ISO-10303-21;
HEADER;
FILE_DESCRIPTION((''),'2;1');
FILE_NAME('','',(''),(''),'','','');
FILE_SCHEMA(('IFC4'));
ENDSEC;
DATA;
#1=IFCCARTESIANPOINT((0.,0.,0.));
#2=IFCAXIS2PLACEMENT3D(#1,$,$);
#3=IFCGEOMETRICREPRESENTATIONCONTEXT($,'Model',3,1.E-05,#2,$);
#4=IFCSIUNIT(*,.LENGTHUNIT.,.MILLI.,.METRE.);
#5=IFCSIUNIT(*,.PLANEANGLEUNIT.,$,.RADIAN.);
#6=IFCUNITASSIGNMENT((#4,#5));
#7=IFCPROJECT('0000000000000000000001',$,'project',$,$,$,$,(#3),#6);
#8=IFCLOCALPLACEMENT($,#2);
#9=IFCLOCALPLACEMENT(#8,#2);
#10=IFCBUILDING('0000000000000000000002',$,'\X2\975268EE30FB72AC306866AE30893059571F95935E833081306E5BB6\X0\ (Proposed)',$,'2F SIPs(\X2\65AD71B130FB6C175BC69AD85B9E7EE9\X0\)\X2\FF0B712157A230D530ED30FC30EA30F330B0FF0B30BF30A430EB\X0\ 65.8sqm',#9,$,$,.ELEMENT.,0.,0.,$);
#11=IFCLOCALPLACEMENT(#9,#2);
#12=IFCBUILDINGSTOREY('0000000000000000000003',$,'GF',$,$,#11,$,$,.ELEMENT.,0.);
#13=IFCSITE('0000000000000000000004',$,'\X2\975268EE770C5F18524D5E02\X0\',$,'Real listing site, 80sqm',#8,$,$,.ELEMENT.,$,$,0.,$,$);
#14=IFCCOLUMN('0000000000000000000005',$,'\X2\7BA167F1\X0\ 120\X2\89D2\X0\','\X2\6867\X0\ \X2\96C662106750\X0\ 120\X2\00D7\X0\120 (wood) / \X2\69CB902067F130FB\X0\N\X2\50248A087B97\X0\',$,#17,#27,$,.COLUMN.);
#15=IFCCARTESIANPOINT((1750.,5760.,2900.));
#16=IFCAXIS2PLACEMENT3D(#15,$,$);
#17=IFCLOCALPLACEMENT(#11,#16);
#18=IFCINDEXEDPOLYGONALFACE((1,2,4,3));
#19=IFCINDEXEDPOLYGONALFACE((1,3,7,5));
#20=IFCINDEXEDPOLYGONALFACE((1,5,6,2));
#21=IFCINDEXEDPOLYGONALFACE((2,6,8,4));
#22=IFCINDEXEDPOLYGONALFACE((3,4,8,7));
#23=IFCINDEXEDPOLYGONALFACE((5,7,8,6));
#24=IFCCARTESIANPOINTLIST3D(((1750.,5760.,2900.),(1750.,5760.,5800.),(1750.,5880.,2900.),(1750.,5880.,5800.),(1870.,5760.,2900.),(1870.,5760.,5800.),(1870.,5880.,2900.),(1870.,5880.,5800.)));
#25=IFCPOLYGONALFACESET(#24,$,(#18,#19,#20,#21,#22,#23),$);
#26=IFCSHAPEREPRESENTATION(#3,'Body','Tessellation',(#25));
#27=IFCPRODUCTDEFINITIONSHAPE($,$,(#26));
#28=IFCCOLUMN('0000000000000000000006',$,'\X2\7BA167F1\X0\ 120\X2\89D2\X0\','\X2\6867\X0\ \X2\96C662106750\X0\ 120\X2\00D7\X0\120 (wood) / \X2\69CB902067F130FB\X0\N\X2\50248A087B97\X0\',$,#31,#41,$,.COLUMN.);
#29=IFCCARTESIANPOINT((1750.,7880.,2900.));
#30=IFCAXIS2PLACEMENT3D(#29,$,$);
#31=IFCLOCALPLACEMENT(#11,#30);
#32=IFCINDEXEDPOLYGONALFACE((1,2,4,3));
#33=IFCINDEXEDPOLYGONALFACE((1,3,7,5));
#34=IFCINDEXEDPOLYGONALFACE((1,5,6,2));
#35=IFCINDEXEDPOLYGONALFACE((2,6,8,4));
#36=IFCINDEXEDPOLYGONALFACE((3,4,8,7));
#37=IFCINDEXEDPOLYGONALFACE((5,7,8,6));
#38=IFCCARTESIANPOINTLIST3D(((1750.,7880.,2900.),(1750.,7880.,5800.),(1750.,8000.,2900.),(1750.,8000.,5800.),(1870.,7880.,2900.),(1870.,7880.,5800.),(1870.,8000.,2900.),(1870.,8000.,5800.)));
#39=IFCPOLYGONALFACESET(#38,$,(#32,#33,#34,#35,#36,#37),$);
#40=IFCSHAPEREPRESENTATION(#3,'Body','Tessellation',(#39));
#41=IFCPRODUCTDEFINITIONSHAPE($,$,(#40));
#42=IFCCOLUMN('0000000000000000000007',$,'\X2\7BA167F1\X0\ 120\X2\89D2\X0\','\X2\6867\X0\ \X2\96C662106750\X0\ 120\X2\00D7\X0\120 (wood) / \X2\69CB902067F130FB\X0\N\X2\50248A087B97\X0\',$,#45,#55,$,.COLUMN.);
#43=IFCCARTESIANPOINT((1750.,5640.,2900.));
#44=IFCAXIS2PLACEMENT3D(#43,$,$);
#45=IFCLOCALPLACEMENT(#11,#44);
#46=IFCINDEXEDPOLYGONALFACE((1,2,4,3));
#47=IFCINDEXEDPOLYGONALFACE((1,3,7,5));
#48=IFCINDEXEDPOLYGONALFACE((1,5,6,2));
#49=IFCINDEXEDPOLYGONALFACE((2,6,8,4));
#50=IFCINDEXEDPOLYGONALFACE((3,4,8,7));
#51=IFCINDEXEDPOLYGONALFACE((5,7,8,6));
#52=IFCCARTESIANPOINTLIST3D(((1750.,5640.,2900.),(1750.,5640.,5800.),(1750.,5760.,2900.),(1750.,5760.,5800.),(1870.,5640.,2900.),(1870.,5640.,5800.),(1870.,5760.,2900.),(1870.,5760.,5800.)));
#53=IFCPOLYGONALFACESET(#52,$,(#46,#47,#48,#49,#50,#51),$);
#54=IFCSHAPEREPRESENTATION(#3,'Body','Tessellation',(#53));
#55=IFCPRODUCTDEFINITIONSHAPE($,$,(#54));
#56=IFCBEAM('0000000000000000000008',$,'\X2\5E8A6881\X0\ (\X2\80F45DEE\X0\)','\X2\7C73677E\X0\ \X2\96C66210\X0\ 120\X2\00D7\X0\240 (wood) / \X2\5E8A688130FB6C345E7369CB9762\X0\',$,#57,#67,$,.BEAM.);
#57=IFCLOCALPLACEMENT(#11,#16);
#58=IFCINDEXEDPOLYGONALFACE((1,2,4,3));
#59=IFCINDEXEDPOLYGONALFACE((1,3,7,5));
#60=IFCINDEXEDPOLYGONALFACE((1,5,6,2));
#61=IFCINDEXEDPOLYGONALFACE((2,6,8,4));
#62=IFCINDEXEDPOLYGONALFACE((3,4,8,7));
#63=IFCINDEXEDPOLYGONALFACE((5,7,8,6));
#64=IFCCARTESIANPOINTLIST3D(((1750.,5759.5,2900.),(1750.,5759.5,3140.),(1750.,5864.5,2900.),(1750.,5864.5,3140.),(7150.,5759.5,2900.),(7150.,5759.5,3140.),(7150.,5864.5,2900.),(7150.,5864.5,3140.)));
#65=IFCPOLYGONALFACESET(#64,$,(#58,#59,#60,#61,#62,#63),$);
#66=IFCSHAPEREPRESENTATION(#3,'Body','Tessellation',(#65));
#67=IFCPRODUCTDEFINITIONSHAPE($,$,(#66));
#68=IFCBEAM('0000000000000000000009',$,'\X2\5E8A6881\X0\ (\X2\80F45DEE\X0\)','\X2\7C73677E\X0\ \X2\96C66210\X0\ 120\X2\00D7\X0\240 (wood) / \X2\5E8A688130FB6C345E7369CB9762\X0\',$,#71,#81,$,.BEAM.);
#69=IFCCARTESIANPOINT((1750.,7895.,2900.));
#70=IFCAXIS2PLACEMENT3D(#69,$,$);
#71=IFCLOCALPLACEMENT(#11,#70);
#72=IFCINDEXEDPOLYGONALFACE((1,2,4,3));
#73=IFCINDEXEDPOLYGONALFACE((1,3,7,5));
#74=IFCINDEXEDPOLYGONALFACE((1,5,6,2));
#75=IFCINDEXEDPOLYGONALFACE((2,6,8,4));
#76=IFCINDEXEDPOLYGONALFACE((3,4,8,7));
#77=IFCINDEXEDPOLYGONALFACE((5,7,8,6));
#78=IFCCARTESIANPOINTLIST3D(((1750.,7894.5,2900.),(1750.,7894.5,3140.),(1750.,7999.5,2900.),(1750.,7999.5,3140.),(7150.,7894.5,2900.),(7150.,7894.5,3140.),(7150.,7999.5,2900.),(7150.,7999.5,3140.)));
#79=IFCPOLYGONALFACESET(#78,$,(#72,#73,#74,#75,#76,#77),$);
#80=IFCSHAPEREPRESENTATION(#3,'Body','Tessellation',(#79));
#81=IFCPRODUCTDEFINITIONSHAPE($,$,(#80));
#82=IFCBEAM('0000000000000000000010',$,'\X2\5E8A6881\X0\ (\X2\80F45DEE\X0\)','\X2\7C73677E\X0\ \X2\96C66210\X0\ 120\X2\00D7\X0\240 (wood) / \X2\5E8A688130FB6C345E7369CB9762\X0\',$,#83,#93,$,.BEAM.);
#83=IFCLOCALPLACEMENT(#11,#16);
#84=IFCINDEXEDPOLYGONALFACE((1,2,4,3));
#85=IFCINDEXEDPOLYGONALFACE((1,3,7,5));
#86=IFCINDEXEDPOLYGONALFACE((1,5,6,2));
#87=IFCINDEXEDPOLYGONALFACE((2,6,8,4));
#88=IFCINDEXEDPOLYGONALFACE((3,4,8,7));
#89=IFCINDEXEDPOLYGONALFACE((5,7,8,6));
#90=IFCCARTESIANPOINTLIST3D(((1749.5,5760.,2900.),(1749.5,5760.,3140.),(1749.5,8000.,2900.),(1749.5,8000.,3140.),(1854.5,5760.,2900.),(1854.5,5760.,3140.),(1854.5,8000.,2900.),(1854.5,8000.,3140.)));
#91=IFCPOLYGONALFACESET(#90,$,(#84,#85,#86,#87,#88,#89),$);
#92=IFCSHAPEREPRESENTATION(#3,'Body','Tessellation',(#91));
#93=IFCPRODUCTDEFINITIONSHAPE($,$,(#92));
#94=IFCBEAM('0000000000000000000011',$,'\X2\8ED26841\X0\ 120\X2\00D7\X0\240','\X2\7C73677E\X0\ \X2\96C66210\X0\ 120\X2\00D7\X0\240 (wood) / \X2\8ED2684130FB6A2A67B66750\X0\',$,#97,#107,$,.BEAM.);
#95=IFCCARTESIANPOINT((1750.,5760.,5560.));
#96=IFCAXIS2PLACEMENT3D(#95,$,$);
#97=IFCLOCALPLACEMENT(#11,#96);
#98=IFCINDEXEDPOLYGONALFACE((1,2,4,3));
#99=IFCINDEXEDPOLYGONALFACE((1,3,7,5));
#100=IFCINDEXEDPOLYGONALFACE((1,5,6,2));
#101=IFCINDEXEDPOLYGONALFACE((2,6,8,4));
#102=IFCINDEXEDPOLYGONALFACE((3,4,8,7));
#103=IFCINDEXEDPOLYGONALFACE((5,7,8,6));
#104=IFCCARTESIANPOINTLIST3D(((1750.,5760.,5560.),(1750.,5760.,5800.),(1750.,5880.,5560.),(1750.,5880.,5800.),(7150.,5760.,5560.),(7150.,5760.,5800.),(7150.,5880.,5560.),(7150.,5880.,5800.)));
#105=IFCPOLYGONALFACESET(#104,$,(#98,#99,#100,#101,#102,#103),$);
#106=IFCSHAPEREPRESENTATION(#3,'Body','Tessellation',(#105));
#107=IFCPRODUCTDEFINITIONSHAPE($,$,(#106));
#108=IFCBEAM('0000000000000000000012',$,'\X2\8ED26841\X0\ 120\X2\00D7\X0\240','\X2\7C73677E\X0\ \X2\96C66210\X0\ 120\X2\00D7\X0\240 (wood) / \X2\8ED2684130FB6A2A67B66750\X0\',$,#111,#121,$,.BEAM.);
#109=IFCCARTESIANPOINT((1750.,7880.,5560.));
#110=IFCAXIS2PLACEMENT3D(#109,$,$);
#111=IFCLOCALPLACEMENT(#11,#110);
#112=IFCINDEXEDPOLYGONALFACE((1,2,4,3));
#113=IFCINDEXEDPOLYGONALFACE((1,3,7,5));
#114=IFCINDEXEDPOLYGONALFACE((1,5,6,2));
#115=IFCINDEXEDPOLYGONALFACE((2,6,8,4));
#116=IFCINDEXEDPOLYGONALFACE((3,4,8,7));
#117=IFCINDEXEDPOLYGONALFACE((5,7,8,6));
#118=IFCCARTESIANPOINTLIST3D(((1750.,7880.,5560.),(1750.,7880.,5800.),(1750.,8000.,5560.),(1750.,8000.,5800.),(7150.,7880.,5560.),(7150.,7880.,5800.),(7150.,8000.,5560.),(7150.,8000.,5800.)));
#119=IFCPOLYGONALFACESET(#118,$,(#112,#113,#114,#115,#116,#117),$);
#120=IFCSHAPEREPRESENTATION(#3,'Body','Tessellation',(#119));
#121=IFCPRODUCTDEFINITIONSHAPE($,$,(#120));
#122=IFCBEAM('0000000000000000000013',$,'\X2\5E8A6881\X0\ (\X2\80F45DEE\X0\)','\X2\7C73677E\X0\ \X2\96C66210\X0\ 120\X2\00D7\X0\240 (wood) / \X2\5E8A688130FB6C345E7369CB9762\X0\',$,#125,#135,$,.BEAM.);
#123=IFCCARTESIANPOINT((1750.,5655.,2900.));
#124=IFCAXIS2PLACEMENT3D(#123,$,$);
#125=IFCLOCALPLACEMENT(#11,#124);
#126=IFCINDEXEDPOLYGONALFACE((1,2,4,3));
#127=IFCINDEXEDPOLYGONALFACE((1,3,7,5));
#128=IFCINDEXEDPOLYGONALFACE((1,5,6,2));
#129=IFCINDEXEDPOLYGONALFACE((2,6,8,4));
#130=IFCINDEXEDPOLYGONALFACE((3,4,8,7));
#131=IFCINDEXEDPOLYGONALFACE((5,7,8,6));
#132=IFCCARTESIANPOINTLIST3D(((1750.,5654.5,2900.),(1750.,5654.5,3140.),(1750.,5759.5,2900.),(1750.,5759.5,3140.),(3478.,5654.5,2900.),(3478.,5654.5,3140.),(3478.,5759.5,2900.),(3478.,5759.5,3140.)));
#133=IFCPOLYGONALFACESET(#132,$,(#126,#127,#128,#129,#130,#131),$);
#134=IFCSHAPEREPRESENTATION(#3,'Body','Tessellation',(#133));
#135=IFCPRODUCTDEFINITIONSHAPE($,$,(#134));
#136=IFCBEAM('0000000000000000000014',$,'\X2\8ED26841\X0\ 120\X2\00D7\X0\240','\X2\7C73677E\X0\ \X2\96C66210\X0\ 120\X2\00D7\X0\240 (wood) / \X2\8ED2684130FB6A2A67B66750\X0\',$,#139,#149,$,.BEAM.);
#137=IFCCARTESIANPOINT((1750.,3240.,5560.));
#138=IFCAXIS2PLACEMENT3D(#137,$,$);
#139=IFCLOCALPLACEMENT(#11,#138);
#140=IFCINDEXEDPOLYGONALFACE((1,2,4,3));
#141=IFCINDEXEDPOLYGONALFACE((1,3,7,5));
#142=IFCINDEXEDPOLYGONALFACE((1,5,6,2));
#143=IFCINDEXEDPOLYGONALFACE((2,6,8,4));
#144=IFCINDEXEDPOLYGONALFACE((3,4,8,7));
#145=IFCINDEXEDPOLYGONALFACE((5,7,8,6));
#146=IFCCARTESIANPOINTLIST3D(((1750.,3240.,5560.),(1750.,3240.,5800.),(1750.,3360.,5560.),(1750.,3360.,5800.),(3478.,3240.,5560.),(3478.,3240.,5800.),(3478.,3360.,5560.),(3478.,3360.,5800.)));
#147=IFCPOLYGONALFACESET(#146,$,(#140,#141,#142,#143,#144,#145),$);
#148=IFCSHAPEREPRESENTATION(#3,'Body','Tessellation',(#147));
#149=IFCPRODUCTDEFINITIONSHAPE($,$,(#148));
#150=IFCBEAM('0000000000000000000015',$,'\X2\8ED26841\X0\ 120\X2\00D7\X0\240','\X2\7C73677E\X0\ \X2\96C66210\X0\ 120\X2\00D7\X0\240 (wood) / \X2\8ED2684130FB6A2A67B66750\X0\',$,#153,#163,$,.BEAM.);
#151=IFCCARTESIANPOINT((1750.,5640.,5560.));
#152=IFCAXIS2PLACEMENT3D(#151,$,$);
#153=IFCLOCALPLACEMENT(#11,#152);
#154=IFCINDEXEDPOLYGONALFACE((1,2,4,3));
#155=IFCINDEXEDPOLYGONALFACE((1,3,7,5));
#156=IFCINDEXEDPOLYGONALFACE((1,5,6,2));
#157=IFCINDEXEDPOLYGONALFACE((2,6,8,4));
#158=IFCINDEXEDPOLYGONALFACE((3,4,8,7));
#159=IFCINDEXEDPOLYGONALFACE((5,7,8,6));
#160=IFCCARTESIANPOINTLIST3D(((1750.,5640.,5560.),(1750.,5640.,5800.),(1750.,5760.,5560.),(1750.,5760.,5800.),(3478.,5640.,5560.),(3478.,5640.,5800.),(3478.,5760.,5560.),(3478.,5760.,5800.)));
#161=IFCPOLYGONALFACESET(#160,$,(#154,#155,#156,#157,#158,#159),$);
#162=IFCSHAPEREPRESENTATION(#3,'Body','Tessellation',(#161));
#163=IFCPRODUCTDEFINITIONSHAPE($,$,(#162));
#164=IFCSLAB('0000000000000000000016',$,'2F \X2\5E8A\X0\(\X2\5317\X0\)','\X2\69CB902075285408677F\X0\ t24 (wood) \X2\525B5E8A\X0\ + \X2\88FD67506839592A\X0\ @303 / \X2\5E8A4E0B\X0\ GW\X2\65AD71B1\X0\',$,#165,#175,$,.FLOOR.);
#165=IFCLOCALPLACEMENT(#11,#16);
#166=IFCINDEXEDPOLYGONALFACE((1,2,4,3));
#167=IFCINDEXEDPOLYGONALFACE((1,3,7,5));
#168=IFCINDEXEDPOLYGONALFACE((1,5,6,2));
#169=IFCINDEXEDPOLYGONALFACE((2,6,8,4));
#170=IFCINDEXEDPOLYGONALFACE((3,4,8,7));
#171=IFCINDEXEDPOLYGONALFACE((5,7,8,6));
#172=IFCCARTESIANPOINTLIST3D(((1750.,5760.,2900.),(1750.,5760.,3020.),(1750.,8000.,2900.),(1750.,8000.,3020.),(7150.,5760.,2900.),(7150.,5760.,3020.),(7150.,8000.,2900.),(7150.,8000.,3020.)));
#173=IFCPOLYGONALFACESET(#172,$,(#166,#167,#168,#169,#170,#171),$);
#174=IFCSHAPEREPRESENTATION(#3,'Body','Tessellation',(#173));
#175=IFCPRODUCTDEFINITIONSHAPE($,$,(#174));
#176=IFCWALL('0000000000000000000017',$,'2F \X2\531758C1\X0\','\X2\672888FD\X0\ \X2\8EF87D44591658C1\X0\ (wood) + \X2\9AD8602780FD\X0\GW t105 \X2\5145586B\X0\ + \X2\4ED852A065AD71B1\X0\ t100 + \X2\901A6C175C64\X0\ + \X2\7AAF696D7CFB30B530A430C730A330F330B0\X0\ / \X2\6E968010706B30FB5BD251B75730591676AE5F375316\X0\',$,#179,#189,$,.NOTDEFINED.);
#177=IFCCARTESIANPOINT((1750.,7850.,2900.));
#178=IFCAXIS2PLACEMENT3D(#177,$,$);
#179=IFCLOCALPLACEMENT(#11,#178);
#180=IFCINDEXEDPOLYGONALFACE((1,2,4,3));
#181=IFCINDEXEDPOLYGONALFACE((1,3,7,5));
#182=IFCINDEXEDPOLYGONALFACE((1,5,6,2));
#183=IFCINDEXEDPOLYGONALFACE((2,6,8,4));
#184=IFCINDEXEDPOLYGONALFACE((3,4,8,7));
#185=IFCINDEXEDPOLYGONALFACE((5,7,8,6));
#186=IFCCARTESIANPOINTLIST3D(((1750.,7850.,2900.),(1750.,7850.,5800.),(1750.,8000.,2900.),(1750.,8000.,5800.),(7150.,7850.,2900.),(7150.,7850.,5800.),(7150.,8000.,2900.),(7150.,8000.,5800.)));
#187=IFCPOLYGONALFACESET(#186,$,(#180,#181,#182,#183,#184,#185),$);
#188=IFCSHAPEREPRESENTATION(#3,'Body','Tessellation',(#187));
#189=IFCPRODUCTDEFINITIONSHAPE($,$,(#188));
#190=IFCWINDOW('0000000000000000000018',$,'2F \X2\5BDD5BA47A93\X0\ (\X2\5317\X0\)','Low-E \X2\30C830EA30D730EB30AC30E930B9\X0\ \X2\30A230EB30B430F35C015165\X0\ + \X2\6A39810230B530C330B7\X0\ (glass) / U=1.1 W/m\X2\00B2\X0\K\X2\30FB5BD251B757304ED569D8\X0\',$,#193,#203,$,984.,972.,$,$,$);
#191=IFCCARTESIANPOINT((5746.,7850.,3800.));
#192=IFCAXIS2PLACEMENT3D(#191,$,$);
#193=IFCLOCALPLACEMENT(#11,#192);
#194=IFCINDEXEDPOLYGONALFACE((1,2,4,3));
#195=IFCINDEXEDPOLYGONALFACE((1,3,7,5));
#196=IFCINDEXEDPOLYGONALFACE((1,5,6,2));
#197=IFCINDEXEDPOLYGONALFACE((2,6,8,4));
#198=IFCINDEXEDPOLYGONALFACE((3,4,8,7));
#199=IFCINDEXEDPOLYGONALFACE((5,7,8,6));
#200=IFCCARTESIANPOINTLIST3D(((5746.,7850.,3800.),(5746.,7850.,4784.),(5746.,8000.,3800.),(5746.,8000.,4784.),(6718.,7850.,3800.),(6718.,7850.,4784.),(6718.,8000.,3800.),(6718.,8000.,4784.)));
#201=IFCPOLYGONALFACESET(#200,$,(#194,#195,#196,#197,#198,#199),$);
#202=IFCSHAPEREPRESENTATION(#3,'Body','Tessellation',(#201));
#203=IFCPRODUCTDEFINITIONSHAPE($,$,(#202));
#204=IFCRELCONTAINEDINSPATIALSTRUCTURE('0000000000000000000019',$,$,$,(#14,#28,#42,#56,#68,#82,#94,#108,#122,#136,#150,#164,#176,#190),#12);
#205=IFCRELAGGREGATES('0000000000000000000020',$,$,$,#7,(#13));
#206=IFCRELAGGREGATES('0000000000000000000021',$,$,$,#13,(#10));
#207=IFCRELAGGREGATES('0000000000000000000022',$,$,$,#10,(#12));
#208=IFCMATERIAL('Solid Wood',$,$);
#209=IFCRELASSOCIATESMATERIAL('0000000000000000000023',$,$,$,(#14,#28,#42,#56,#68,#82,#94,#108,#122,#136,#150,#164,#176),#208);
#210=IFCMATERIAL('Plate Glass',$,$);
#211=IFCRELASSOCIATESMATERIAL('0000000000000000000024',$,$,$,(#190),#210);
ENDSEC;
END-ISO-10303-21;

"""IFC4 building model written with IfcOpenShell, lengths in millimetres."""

from ifc_helpers import new_model, si_unit, frame, frame_2d, origin, place, context, project, spatial, rectangle, extrude, material, element, fill, save


model = new_model("IFC4")

# Units and contexts
model_context = context("Model", 3, precision=1e-05, world=origin())
ifc_project = project(units=[si_unit("LENGTHUNIT", "METRE", prefix="MILLI"), si_unit("PLANEANGLEUNIT", "RADIAN")], contexts=[model_context])

# Site, building, storey
site_placement = place(None, origin())
site = spatial("IfcSite", under=ifc_project, at=site_placement, Name="青森県弘前市", ObjectType="Real listing site, 80sqm", CompositionType="ELEMENT", RefElevation=0.0)
building_placement = place(site_placement, origin())
building = spatial("IfcBuilding", under=site, at=building_placement, Name="青森・犬と暮らす土間広めの家 (Proposed)", ObjectType="2F SIPs(断熱・気密高实绩)＋無垢フローリング＋タイル 65.8sqm", CompositionType="ELEMENT", ElevationOfRefHeight=0.0, ElevationOfTerrain=0.0)
storey_placement = place(building_placement, origin())
storey = spatial("IfcBuildingStorey", under=building, at=storey_placement, Name="GF", CompositionType="ELEMENT", Elevation=0.0)

# Columns
ifc_material_1 = material(Name="Solid Wood")
column_1_placement = place(storey_placement, frame((1750.0, 5760.0, 2900.0)))
element("IfcColumn", 1, at=column_1_placement, inside=storey, material=ifc_material_1, Name="管柱 120角", Description="桧 集成材 120×120 (wood) / 構造柱・N値計算", PredefinedType="COLUMN", context=model_context, shape_type="SweptSolid", body=[
    extrude(rectangle(XDim=120.0, YDim=120.0, at=frame_2d((60.0, 60.0))), frame((1750.0, 5760.0, 2900.0)), (0.0, 0.0, 1.0), 2900.0),
])
column_2_placement = place(storey_placement, frame((1750.0, 7880.0, 2900.0)))
element("IfcColumn", 2, at=column_2_placement, inside=storey, material=ifc_material_1, Name="管柱 120角", Description="桧 集成材 120×120 (wood) / 構造柱・N値計算", PredefinedType="COLUMN", context=model_context, shape_type="SweptSolid", body=[
    extrude(rectangle(XDim=120.0, YDim=120.0, at=frame_2d((60.0, 60.0))), frame((1750.0, 7880.0, 2900.0)), (0.0, 0.0, 1.0), 2900.0),
])
column_3_placement = place(storey_placement, frame((1750.0, 5640.0, 2900.0)))
element("IfcColumn", 3, at=column_3_placement, inside=storey, material=ifc_material_1, Name="管柱 120角", Description="桧 集成材 120×120 (wood) / 構造柱・N値計算", PredefinedType="COLUMN", context=model_context, shape_type="SweptSolid", body=[
    extrude(rectangle(XDim=120.0, YDim=120.0, at=frame_2d((60.0, 60.0))), frame((1750.0, 5640.0, 2900.0)), (0.0, 0.0, 1.0), 2900.0),
])

# Beams
beam_1_placement = place(storey_placement, frame((1750.0, 5760.0, 2900.0)))
element("IfcBeam", 4, at=beam_1_placement, inside=storey, material=ifc_material_1, Name="床梁 (胴差)", Description="米松 集成 120×240 (wood) / 床梁・水平構面", PredefinedType="BEAM", context=model_context, shape_type="SweptSolid", body=[
    extrude(rectangle(XDim=5400.0, YDim=105.0, at=frame_2d((2700.0, 52.0))), frame((1750.0, 5760.0, 2900.0)), (0.0, 0.0, 1.0), 240.0),
])
beam_2_placement = place(storey_placement, frame((1750.0, 7895.0, 2900.0)))
element("IfcBeam", 5, at=beam_2_placement, inside=storey, material=ifc_material_1, Name="床梁 (胴差)", Description="米松 集成 120×240 (wood) / 床梁・水平構面", PredefinedType="BEAM", context=model_context, shape_type="SweptSolid", body=[
    extrude(rectangle(XDim=5400.0, YDim=105.0, at=frame_2d((2700.0, 52.0))), frame((1750.0, 7895.0, 2900.0)), (0.0, 0.0, 1.0), 240.0),
])
beam_3_placement = place(storey_placement, frame((1750.0, 5760.0, 2900.0)))
element("IfcBeam", 6, at=beam_3_placement, inside=storey, material=ifc_material_1, Name="床梁 (胴差)", Description="米松 集成 120×240 (wood) / 床梁・水平構面", PredefinedType="BEAM", context=model_context, shape_type="SweptSolid", body=[
    extrude(rectangle(XDim=105.0, YDim=2240.0, at=frame_2d((52.0, 1120.0))), frame((1750.0, 5760.0, 2900.0)), (0.0, 0.0, 1.0), 240.0),
])
beam_4_placement = place(storey_placement, frame((1750.0, 5760.0, 5560.0)))
element("IfcBeam", 7, at=beam_4_placement, inside=storey, material=ifc_material_1, Name="軒桁 120×240", Description="米松 集成 120×240 (wood) / 軒桁・横架材", PredefinedType="BEAM", context=model_context, shape_type="SweptSolid", body=[
    extrude(rectangle(XDim=5400.0, YDim=120.0, at=frame_2d((2700.0, 60.0))), frame((1750.0, 5760.0, 5560.0)), (0.0, 0.0, 1.0), 240.0),
])
beam_5_placement = place(storey_placement, frame((1750.0, 7880.0, 5560.0)))
element("IfcBeam", 8, at=beam_5_placement, inside=storey, material=ifc_material_1, Name="軒桁 120×240", Description="米松 集成 120×240 (wood) / 軒桁・横架材", PredefinedType="BEAM", context=model_context, shape_type="SweptSolid", body=[
    extrude(rectangle(XDim=5400.0, YDim=120.0, at=frame_2d((2700.0, 60.0))), frame((1750.0, 7880.0, 5560.0)), (0.0, 0.0, 1.0), 240.0),
])
beam_6_placement = place(storey_placement, frame((1750.0, 5655.0, 2900.0)))
element("IfcBeam", 9, at=beam_6_placement, inside=storey, material=ifc_material_1, Name="床梁 (胴差)", Description="米松 集成 120×240 (wood) / 床梁・水平構面", PredefinedType="BEAM", context=model_context, shape_type="SweptSolid", body=[
    extrude(rectangle(XDim=1728.0, YDim=105.0, at=frame_2d((864.0, 52.0))), frame((1750.0, 5655.0, 2900.0)), (0.0, 0.0, 1.0), 240.0),
])
beam_7_placement = place(storey_placement, frame((1750.0, 3240.0, 5560.0)))
element("IfcBeam", 10, at=beam_7_placement, inside=storey, material=ifc_material_1, Name="軒桁 120×240", Description="米松 集成 120×240 (wood) / 軒桁・横架材", PredefinedType="BEAM", context=model_context, shape_type="SweptSolid", body=[
    extrude(rectangle(XDim=1728.0, YDim=120.0, at=frame_2d((864.0, 60.0))), frame((1750.0, 3240.0, 5560.0)), (0.0, 0.0, 1.0), 240.0),
])
beam_8_placement = place(storey_placement, frame((1750.0, 5640.0, 5560.0)))
element("IfcBeam", 11, at=beam_8_placement, inside=storey, material=ifc_material_1, Name="軒桁 120×240", Description="米松 集成 120×240 (wood) / 軒桁・横架材", PredefinedType="BEAM", context=model_context, shape_type="SweptSolid", body=[
    extrude(rectangle(XDim=1728.0, YDim=120.0, at=frame_2d((864.0, 60.0))), frame((1750.0, 5640.0, 5560.0)), (0.0, 0.0, 1.0), 240.0),
])

# Slab
slab_placement = place(storey_placement, frame((1750.0, 5760.0, 2900.0)))
element("IfcSlab", 12, at=slab_placement, inside=storey, material=ifc_material_1, Name="2F 床(北)", Description="構造用合板 t24 (wood) 剛床 + 製材根太 @303 / 床下 GW断熱", PredefinedType="FLOOR", context=model_context, shape_type="SweptSolid", body=[
    extrude(rectangle(XDim=5400.0, YDim=2240.0, at=frame_2d((2700.0, 1120.0))), frame((1750.0, 5760.0, 2900.0)), (0.0, 0.0, 1.0), 120.0),
])

# Wall, opening, window
wall_placement = place(storey_placement, frame((1750.0, 7850.0, 2900.0)))
wall = element("IfcWall", 13, at=wall_placement, inside=storey, material=ifc_material_1, Name="2F 北壁", Description="木製 軸組外壁 (wood) + 高性能GW t105 充填 + 付加断熱 t100 + 通気層 + 窯業系サイディング / 準耐火・寒冷地外皮強化", PredefinedType="NOTDEFINED", context=model_context, shape_type="SweptSolid", body=[
    extrude(rectangle(XDim=5400.0, YDim=150.0, at=frame_2d((2700.0, 75.0))), frame((1750.0, 7850.0, 2900.0)), (0.0, 0.0, 1.0), 2900.0),
])
opening_placement = place(storey_placement, frame((5746.0, 7850.0, 3800.0)))
opening = element("IfcOpeningElement", 14, at=opening_placement, cuts=wall, PredefinedType="NOTDEFINED", context=model_context, shape_type="SweptSolid", body=[
    extrude(rectangle(XDim=972.0, YDim=150.0, at=frame_2d((486.0, 75.0))), frame((5746.0, 7850.0, 3800.0)), (0.0, 0.0, 1.0), 984.0),
])
ifc_material_2 = material(Name="Plate Glass")
window_placement = place(storey_placement, frame((5746.0, 7850.0, 3800.0)))
window = element("IfcWindow", 15, at=window_placement, inside=storey, material=ifc_material_2, Name="2F 寝室窓 (北)", Description="Low-E トリプルガラス アルゴン封入 + 樹脂サッシ (glass) / U=1.1 W/m²K・寒冷地仕様", OverallHeight=984.0, OverallWidth=972.0, context=model_context, shape_type="SweptSolid", body=[
    extrude(rectangle(XDim=972.0, YDim=150.0, at=frame_2d((486.0, 75.0))), frame((5746.0, 7850.0, 3800.0)), (0.0, 0.0, 1.0), 984.0),
])
fill(opening, window)

save(model, "model.ifc")
